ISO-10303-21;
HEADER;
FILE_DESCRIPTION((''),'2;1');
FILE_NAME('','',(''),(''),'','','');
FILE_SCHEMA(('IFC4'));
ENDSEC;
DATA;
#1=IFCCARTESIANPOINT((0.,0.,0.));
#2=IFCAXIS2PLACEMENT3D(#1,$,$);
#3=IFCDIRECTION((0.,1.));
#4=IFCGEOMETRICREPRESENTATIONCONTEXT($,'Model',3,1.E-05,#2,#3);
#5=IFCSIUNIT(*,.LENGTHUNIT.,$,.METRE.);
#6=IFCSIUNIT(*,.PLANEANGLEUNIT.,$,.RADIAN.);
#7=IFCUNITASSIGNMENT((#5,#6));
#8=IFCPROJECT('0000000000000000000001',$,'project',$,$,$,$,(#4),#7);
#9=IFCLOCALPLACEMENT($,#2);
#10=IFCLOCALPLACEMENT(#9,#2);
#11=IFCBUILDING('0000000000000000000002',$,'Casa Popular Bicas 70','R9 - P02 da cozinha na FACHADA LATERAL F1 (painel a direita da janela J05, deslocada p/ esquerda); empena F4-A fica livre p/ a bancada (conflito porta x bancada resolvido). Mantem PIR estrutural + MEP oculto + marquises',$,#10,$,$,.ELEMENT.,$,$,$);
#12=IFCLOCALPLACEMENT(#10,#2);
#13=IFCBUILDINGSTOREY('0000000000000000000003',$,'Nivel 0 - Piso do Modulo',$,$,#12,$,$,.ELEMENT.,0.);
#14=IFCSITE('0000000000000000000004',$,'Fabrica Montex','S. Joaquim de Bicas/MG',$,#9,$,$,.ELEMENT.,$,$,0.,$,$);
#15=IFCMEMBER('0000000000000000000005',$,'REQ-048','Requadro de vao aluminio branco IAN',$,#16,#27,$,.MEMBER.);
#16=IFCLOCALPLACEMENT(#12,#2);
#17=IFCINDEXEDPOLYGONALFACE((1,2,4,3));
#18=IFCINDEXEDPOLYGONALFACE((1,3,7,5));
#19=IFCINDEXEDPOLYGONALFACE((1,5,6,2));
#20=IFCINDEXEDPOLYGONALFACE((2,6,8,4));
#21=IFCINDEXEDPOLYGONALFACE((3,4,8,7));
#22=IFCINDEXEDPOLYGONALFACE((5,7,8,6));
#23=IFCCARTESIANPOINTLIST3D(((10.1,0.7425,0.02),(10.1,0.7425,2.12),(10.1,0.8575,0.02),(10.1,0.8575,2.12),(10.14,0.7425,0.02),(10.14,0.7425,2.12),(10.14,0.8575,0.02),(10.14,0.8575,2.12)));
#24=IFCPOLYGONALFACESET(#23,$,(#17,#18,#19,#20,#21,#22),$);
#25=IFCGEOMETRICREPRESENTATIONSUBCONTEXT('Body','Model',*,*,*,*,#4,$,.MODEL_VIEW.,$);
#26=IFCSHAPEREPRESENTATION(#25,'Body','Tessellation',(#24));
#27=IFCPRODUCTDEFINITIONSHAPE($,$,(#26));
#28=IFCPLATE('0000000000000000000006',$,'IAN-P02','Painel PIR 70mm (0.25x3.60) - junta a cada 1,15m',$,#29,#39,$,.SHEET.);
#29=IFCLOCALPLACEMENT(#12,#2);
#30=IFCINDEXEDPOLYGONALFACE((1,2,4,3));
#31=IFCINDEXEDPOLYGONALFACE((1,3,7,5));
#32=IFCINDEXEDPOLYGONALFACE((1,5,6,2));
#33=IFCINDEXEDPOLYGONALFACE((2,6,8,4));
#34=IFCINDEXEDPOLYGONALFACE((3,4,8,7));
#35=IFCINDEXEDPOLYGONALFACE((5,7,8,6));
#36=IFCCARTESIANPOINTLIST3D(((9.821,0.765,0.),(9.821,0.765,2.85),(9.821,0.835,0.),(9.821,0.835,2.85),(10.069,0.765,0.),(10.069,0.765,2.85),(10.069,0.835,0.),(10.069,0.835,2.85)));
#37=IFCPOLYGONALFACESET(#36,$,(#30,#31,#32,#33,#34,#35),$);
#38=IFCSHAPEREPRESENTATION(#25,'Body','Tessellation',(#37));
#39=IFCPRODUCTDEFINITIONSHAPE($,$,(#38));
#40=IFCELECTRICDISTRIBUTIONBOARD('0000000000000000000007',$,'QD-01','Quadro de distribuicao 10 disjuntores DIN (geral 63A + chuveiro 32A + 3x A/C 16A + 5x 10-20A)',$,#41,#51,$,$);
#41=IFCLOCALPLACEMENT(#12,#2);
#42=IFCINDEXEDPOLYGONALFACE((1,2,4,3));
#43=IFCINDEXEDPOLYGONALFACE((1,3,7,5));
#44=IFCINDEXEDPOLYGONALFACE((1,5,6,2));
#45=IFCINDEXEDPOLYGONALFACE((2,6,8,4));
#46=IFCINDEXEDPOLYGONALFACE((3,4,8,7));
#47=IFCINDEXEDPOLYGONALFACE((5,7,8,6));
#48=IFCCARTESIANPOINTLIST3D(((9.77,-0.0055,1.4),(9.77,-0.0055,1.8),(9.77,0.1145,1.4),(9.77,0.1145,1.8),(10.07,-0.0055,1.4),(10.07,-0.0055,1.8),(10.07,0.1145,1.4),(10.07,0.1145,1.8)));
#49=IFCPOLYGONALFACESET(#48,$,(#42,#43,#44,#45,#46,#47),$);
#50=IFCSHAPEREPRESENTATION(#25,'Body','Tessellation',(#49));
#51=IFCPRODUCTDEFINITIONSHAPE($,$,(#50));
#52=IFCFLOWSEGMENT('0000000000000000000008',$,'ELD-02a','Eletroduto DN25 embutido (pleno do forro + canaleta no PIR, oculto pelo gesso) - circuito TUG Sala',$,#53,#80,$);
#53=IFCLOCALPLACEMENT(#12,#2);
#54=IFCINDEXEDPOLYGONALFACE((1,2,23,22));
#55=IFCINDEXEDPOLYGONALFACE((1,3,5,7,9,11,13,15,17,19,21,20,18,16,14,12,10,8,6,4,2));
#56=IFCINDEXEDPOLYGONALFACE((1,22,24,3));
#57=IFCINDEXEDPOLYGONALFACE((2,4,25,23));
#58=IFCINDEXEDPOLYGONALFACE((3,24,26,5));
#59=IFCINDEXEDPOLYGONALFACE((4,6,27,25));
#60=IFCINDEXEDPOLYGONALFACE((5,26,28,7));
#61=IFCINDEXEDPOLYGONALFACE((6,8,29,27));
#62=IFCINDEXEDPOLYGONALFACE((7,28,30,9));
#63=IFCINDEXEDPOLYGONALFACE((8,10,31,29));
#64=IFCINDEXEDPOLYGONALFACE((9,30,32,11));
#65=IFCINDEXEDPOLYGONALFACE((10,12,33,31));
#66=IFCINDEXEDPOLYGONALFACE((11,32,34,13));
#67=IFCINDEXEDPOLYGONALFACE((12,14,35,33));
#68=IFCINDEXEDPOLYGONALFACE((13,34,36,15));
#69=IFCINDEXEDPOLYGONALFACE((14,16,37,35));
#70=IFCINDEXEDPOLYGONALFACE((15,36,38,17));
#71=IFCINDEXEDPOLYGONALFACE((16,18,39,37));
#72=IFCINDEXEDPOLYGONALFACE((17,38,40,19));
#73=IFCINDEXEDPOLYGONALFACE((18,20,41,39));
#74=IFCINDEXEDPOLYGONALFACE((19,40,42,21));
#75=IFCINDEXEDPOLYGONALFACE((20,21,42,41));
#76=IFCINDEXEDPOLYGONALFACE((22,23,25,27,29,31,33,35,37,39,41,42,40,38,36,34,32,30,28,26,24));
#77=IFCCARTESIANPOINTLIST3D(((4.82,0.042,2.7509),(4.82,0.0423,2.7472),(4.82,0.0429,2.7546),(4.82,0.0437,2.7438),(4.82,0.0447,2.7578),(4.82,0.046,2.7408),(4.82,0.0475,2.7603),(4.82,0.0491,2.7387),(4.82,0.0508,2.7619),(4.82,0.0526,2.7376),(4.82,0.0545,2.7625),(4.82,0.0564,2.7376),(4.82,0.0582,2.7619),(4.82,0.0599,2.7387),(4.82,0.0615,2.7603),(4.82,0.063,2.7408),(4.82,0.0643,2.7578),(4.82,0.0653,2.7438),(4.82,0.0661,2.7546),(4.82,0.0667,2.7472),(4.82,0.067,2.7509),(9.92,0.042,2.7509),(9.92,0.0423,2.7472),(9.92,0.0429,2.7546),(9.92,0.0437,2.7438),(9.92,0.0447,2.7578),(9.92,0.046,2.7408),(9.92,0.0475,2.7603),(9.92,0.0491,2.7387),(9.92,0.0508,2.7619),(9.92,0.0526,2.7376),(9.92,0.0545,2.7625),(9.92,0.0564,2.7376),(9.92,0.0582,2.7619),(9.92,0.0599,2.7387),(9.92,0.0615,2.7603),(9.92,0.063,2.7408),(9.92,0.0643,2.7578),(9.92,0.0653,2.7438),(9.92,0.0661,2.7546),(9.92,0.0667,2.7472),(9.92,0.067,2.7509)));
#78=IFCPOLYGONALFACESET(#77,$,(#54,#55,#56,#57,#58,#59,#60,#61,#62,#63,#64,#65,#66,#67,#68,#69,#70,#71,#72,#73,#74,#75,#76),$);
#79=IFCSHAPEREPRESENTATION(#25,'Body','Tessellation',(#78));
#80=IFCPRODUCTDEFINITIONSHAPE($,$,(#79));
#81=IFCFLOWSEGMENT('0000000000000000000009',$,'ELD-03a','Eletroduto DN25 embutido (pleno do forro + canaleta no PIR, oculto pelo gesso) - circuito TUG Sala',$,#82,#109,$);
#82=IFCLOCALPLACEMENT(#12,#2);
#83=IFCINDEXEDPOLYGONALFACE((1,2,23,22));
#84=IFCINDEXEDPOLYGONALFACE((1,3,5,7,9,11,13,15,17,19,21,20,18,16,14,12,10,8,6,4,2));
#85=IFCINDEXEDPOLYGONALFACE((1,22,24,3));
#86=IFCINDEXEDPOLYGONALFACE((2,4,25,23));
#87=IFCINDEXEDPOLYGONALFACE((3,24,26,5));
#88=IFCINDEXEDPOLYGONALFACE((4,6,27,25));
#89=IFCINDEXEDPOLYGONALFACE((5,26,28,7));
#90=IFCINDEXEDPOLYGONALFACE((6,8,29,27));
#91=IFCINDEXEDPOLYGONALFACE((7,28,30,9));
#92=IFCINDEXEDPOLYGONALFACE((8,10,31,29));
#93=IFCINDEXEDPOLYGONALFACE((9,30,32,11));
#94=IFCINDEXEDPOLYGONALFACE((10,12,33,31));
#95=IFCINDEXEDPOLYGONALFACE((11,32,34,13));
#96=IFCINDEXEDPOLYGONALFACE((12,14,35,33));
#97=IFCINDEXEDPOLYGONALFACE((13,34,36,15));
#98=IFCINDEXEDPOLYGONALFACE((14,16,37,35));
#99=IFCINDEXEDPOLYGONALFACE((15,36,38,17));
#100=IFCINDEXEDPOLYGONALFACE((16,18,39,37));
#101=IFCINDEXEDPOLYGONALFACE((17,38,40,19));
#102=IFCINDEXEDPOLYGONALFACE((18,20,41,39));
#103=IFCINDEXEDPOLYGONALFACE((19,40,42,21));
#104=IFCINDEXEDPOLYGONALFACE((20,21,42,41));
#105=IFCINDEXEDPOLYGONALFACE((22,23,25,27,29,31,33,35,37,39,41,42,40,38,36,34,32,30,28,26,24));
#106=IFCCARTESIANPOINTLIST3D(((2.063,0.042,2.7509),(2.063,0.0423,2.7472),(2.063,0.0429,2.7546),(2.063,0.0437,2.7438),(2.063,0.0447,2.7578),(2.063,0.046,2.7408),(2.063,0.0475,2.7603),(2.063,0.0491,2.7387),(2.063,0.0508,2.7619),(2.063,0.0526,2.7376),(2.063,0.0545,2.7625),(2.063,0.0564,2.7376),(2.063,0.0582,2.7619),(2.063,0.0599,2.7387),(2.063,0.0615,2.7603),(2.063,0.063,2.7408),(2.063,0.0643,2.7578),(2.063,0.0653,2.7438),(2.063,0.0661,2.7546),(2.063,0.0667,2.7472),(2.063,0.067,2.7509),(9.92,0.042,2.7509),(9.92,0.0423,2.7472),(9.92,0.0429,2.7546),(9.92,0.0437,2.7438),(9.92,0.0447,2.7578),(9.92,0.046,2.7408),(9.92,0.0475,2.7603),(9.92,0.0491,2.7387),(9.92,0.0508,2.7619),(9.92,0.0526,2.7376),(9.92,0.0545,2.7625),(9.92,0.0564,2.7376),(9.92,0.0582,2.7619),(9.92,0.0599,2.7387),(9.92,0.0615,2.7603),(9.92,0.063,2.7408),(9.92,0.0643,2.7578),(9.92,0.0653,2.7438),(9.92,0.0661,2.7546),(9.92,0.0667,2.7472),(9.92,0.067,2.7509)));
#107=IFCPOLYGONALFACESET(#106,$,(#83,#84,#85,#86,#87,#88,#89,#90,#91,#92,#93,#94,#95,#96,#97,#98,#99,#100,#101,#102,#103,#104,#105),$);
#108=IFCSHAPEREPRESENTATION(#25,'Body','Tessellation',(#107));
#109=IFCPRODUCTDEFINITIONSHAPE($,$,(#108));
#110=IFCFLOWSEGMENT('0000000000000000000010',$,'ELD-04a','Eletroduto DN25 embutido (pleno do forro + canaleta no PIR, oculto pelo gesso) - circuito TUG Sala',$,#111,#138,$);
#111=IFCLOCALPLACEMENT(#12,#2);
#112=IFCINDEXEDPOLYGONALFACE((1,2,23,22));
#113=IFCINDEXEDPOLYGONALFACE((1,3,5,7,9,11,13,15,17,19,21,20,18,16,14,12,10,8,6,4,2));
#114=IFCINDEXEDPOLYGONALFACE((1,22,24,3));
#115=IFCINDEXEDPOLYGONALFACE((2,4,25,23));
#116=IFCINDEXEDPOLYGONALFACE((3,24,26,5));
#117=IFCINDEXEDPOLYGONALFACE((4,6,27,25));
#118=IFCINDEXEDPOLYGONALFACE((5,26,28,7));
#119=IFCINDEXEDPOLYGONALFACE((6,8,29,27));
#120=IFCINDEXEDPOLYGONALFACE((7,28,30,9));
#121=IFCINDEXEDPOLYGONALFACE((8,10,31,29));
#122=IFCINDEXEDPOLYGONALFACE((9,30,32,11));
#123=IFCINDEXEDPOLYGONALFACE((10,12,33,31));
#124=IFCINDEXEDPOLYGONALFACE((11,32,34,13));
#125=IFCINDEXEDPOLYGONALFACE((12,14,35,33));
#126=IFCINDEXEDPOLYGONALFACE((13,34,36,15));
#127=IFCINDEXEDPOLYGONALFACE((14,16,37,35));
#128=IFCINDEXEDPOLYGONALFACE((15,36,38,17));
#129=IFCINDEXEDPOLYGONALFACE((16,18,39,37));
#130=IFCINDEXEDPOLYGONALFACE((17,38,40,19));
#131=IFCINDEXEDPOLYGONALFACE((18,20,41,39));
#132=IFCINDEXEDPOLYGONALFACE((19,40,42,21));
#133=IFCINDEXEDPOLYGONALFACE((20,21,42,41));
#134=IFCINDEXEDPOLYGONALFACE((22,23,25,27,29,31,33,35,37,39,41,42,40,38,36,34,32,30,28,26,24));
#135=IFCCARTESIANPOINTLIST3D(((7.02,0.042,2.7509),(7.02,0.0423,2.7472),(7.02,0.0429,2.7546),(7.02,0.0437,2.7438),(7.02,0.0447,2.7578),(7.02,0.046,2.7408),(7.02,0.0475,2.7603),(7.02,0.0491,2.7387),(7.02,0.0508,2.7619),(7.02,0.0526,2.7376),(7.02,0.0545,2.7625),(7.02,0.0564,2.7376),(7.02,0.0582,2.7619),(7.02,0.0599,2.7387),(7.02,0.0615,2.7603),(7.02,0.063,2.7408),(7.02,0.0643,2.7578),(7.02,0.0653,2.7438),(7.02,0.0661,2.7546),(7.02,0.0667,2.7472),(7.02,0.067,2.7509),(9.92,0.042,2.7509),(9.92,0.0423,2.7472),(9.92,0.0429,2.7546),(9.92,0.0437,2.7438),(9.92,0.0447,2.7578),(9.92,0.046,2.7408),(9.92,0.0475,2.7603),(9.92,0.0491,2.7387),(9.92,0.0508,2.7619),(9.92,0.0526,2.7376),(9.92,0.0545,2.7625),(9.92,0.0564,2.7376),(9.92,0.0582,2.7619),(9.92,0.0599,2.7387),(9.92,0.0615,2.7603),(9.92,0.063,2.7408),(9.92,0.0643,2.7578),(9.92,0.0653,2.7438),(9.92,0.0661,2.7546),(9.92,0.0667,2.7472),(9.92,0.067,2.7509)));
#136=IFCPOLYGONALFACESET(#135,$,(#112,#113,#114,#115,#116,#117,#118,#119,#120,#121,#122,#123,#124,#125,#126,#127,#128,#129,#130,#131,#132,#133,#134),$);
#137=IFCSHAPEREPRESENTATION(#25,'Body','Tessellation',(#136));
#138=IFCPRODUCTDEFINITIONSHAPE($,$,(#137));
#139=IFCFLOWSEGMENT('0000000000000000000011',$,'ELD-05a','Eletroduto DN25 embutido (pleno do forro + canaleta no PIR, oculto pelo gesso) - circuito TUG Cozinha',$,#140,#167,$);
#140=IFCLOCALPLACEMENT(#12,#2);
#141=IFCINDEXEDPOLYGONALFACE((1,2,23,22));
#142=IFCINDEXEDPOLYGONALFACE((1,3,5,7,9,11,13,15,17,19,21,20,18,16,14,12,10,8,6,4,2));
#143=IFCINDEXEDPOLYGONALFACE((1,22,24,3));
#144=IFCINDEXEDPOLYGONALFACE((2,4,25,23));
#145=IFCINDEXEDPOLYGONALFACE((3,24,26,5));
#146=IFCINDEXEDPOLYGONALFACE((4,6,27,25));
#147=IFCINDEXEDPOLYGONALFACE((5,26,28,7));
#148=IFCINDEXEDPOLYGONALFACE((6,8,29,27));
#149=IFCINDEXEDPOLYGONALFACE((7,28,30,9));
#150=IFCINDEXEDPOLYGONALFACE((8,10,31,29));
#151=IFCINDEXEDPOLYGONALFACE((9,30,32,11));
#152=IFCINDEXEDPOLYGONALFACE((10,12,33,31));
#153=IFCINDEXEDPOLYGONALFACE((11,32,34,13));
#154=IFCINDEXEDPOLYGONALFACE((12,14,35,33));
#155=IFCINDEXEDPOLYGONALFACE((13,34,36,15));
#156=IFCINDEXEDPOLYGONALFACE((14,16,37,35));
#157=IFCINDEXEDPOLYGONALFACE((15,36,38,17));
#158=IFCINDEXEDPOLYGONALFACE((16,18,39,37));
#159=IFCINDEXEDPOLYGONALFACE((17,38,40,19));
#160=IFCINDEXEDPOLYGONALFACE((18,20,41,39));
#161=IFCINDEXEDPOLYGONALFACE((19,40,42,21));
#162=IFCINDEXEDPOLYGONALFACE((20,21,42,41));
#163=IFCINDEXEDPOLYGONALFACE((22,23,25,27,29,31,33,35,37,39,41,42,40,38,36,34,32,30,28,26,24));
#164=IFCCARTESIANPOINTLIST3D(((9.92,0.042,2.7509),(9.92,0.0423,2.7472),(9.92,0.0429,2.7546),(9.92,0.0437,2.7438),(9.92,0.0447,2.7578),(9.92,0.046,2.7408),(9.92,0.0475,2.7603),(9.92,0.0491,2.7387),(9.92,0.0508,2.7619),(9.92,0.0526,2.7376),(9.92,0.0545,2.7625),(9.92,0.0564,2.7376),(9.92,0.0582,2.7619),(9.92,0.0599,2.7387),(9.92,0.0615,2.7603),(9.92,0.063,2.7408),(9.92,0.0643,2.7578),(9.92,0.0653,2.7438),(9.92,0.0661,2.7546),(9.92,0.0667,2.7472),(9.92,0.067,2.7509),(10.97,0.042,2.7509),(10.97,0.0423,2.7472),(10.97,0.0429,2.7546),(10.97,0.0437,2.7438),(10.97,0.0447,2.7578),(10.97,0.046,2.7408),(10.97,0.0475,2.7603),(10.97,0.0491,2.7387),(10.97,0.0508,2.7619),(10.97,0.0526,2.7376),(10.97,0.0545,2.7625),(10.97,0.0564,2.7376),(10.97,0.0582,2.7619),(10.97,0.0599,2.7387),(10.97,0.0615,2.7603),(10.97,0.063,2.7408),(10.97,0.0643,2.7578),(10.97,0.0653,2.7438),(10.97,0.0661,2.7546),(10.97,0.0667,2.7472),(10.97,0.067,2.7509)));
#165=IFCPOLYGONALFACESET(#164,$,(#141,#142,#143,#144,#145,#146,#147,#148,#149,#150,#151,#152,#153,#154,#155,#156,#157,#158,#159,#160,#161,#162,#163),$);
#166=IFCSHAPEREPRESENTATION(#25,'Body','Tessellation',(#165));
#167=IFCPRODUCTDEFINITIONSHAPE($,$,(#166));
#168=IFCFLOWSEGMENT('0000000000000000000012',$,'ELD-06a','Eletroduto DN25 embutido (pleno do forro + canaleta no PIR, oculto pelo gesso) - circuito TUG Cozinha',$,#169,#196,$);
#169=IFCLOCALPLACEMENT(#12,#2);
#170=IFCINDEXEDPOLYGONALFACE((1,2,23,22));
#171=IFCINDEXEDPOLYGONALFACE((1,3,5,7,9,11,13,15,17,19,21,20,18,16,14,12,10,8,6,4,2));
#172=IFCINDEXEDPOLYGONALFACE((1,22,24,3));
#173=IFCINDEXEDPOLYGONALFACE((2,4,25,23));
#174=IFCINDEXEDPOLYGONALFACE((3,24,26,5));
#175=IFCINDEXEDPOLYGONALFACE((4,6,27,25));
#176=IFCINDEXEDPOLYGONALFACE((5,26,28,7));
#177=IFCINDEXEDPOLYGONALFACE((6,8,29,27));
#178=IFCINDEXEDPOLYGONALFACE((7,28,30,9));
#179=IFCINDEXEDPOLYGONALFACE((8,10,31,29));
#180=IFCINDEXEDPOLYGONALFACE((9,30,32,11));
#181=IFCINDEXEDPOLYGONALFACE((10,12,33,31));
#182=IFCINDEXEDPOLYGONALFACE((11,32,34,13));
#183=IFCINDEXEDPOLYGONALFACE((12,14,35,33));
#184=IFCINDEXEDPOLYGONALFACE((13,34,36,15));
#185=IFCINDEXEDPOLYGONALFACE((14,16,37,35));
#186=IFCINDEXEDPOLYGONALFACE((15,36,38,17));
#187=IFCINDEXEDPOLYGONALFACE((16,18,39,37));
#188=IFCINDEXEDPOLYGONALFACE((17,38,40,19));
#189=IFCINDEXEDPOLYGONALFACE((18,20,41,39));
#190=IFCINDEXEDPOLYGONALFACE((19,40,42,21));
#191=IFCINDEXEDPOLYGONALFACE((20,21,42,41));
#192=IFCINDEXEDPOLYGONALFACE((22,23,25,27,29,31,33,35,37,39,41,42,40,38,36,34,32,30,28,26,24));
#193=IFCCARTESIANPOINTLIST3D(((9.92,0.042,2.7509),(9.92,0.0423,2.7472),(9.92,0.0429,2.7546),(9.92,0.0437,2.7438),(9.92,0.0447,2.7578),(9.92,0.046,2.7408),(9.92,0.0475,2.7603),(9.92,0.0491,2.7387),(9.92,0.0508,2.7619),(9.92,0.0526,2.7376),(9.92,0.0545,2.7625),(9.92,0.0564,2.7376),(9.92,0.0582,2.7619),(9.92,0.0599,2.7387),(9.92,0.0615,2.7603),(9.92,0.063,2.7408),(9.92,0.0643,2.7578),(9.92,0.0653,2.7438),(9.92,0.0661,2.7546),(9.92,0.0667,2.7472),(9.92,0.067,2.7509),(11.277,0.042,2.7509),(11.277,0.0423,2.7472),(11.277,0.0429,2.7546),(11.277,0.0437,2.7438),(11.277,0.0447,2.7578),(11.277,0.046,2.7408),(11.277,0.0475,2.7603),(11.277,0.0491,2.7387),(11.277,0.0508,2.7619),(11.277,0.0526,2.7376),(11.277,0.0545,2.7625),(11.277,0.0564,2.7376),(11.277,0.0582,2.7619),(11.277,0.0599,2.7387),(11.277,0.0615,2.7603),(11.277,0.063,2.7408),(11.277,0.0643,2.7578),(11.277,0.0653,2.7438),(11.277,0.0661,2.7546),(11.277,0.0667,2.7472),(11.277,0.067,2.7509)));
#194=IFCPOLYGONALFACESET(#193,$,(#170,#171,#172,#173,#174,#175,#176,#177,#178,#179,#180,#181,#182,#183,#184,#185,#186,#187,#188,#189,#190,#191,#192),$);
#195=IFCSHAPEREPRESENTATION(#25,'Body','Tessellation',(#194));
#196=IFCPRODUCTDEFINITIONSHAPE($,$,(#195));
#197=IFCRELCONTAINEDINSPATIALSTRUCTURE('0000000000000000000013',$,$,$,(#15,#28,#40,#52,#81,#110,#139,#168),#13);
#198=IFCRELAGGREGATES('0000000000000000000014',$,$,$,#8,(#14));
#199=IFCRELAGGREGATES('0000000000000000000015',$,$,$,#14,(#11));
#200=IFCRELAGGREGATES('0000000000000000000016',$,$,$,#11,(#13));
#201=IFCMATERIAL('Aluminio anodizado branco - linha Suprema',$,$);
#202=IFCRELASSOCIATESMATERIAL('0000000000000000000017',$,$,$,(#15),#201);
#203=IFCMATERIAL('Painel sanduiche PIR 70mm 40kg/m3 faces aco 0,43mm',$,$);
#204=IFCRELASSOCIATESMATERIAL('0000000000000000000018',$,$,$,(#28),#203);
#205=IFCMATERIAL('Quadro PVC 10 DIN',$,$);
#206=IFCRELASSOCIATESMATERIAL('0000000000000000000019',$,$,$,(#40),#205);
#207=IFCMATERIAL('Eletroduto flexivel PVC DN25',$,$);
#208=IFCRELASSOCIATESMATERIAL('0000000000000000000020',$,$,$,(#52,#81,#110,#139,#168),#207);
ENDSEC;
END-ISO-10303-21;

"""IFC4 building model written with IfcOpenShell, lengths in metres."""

from ifc_helpers import new_model, si_unit, direction, frame, frame_2d, origin, origin_2d, place, context, subcontext, project, spatial, rectangle, circle, extrude, material, element, save


model = new_model("IFC4")

# Units and contexts
model_context = context("Model", 3, precision=1e-05, world=origin(), true_north=direction((0.0, 1.0)))
body_context = subcontext(model_context, "Body", "Model", "MODEL_VIEW")
ifc_project = project(units=[si_unit("LENGTHUNIT", "METRE"), si_unit("PLANEANGLEUNIT", "RADIAN")], contexts=[model_context])

# Site, building, storey
site_placement = place(None, origin())
site = spatial("IfcSite", under=ifc_project, at=site_placement, Name="Fabrica Montex", Description="S. Joaquim de Bicas/MG", CompositionType="ELEMENT", RefElevation=0.0)
building_placement = place(site_placement, origin())
building = spatial("IfcBuilding", under=site, at=building_placement, Name="Casa Popular Bicas 70", Description="R9 - P02 da cozinha na FACHADA LATERAL F1 (painel a direita da janela J05, deslocada p/ esquerda); empena F4-A fica livre p/ a bancada (conflito porta x bancada resolvido). Mantem PIR estrutural + MEP oculto + marquises", CompositionType="ELEMENT")
storey_placement = place(building_placement, origin())
storey = spatial("IfcBuildingStorey", under=building, at=storey_placement, Name="Nivel 0 - Piso do Modulo", CompositionType="ELEMENT", Elevation=0.0)

# Member
ifc_material_1 = material(Name="Aluminio anodizado branco - linha Suprema")
member_placement = place(None, frame((10.12, 0.8, 0.02), z_axis=(0.0, 0.0, 1.0), x_axis=(-1.0, 0.0, 0.0)))
element("IfcMember", 1, at=member_placement, inside=storey, material=ifc_material_1, Name="REQ-048", Description="Requadro de vao aluminio branco IAN", PredefinedType="MEMBER", context=body_context, shape_type="SweptSolid", body=[
    extrude(rectangle(XDim=0.04, YDim=0.115, at=origin_2d()), origin(), (0.0, 0.0, 1.0), 2.1),
])

# Shared definitions
ifc_material_2 = material(Name="Painel sanduiche PIR 70mm 40kg/m3 faces aco 0,43mm")

# Plate
plate_1_placement = place(None, frame((10.069, 0.8, 0.0), z_axis=(0.0, 0.0, 1.0), x_axis=(-1.0, 0.0, 0.0)))
element("IfcPlate", 2, at=plate_1_placement, inside=storey, material=ifc_material_2, Name="IAN-P02", Description="Painel PIR 70mm (0.25x3.60) - junta a cada 1,15m", PredefinedType="SHEET", context=body_context, shape_type="SweptSolid", body=[
    extrude(rectangle(XDim=0.248, YDim=0.07, at=frame_2d((0.124, 0.0))), origin(), (0.0, 0.0, 1.0), 2.85),
])

# Electric distribution board
ifc_material_3 = material(Name="Quadro PVC 10 DIN")
electric_distribution_board_placement = place(None, frame((10.07, 0.1145, 1.4), z_axis=(0.0, 0.0, 1.0), x_axis=(-1.0, 0.0, 0.0)))
element("IfcElectricDistributionBoard", 3, at=electric_distribution_board_placement, inside=storey, material=ifc_material_3, Name="QD-01", Description="Quadro de distribuicao 10 disjuntores DIN (geral 63A + chuveiro 32A + 3x A/C 16A + 5x 10-20A)", context=body_context, shape_type="SweptSolid", body=[
    extrude(rectangle(XDim=0.3, YDim=0.12, at=frame_2d((0.15, 0.06))), origin(), (0.0, 0.0, 1.0), 0.4),
])

# Flow segments
ifc_material_4 = material(Name="Eletroduto flexivel PVC DN25")
flow_segment_1_placement = place(None, frame((9.92, 0.0545, 2.75), z_axis=(-1.0, 0.0, 0.0), x_axis=(0.0, 0.0, 1.0)))
element("IfcFlowSegment", 4, at=flow_segment_1_placement, inside=storey, material=ifc_material_4, Name="ELD-02a", Description="Eletroduto DN25 embutido (pleno do forro + canaleta no PIR, oculto pelo gesso) - circuito TUG Sala", context=body_context, shape_type="SweptSolid", body=[
    extrude(circle(Radius=0.0125, at=origin_2d()), origin(), (0.0, 0.0, 1.0), 5.1),
])
flow_segment_2_placement = place(None, frame((9.92, 0.0545, 2.75), z_axis=(-1.0, 0.0, 0.0), x_axis=(0.0, 0.0, 1.0)))
element("IfcFlowSegment", 5, at=flow_segment_2_placement, inside=storey, material=ifc_material_4, Name="ELD-03a", Description="Eletroduto DN25 embutido (pleno do forro + canaleta no PIR, oculto pelo gesso) - circuito TUG Sala", context=body_context, shape_type="SweptSolid", body=[
    extrude(circle(Radius=0.0125, at=origin_2d()), origin(), (0.0, 0.0, 1.0), 7.857),
])
flow_segment_3_placement = place(None, frame((9.92, 0.0545, 2.75), z_axis=(-1.0, 0.0, 0.0), x_axis=(0.0, 0.0, 1.0)))
element("IfcFlowSegment", 6, at=flow_segment_3_placement, inside=storey, material=ifc_material_4, Name="ELD-04a", Description="Eletroduto DN25 embutido (pleno do forro + canaleta no PIR, oculto pelo gesso) - circuito TUG Sala", context=body_context, shape_type="SweptSolid", body=[
    extrude(circle(Radius=0.0125, at=origin_2d()), origin(), (0.0, 0.0, 1.0), 2.9),
])
flow_segment_4_placement = place(None, frame((9.92, 0.0545, 2.75), z_axis=(1.0, 0.0, 0.0), x_axis=(0.0, 0.0, 1.0)))
element("IfcFlowSegment", 7, at=flow_segment_4_placement, inside=storey, material=ifc_material_4, Name="ELD-05a", Description="Eletroduto DN25 embutido (pleno do forro + canaleta no PIR, oculto pelo gesso) - circuito TUG Cozinha", context=body_context, shape_type="SweptSolid", body=[
    extrude(circle(Radius=0.0125, at=origin_2d()), origin(), (0.0, 0.0, 1.0), 1.05),
])
for number, where, z_axis, x_axis, name in (
    (8, (9.92, 0.0545, 2.75), (1.0, 0.0, 0.0), (0.0, 0.0, 1.0), "ELD-06a"),
):
    element("IfcFlowSegment", number, at=place(None, frame(where, z_axis=z_axis, x_axis=x_axis)), inside=storey, material=ifc_material_4, Name=name, Description="Eletroduto DN25 embutido (pleno do forro + canaleta no PIR, oculto pelo gesso) - circuito TUG Cozinha", context=body_context, shape_type="SweptSolid", body=[
        extrude(circle(Radius=0.0125, at=origin_2d()), origin(), (0.0, 0.0, 1.0), 1.357),
    ])

save(model, "model.ifc")
